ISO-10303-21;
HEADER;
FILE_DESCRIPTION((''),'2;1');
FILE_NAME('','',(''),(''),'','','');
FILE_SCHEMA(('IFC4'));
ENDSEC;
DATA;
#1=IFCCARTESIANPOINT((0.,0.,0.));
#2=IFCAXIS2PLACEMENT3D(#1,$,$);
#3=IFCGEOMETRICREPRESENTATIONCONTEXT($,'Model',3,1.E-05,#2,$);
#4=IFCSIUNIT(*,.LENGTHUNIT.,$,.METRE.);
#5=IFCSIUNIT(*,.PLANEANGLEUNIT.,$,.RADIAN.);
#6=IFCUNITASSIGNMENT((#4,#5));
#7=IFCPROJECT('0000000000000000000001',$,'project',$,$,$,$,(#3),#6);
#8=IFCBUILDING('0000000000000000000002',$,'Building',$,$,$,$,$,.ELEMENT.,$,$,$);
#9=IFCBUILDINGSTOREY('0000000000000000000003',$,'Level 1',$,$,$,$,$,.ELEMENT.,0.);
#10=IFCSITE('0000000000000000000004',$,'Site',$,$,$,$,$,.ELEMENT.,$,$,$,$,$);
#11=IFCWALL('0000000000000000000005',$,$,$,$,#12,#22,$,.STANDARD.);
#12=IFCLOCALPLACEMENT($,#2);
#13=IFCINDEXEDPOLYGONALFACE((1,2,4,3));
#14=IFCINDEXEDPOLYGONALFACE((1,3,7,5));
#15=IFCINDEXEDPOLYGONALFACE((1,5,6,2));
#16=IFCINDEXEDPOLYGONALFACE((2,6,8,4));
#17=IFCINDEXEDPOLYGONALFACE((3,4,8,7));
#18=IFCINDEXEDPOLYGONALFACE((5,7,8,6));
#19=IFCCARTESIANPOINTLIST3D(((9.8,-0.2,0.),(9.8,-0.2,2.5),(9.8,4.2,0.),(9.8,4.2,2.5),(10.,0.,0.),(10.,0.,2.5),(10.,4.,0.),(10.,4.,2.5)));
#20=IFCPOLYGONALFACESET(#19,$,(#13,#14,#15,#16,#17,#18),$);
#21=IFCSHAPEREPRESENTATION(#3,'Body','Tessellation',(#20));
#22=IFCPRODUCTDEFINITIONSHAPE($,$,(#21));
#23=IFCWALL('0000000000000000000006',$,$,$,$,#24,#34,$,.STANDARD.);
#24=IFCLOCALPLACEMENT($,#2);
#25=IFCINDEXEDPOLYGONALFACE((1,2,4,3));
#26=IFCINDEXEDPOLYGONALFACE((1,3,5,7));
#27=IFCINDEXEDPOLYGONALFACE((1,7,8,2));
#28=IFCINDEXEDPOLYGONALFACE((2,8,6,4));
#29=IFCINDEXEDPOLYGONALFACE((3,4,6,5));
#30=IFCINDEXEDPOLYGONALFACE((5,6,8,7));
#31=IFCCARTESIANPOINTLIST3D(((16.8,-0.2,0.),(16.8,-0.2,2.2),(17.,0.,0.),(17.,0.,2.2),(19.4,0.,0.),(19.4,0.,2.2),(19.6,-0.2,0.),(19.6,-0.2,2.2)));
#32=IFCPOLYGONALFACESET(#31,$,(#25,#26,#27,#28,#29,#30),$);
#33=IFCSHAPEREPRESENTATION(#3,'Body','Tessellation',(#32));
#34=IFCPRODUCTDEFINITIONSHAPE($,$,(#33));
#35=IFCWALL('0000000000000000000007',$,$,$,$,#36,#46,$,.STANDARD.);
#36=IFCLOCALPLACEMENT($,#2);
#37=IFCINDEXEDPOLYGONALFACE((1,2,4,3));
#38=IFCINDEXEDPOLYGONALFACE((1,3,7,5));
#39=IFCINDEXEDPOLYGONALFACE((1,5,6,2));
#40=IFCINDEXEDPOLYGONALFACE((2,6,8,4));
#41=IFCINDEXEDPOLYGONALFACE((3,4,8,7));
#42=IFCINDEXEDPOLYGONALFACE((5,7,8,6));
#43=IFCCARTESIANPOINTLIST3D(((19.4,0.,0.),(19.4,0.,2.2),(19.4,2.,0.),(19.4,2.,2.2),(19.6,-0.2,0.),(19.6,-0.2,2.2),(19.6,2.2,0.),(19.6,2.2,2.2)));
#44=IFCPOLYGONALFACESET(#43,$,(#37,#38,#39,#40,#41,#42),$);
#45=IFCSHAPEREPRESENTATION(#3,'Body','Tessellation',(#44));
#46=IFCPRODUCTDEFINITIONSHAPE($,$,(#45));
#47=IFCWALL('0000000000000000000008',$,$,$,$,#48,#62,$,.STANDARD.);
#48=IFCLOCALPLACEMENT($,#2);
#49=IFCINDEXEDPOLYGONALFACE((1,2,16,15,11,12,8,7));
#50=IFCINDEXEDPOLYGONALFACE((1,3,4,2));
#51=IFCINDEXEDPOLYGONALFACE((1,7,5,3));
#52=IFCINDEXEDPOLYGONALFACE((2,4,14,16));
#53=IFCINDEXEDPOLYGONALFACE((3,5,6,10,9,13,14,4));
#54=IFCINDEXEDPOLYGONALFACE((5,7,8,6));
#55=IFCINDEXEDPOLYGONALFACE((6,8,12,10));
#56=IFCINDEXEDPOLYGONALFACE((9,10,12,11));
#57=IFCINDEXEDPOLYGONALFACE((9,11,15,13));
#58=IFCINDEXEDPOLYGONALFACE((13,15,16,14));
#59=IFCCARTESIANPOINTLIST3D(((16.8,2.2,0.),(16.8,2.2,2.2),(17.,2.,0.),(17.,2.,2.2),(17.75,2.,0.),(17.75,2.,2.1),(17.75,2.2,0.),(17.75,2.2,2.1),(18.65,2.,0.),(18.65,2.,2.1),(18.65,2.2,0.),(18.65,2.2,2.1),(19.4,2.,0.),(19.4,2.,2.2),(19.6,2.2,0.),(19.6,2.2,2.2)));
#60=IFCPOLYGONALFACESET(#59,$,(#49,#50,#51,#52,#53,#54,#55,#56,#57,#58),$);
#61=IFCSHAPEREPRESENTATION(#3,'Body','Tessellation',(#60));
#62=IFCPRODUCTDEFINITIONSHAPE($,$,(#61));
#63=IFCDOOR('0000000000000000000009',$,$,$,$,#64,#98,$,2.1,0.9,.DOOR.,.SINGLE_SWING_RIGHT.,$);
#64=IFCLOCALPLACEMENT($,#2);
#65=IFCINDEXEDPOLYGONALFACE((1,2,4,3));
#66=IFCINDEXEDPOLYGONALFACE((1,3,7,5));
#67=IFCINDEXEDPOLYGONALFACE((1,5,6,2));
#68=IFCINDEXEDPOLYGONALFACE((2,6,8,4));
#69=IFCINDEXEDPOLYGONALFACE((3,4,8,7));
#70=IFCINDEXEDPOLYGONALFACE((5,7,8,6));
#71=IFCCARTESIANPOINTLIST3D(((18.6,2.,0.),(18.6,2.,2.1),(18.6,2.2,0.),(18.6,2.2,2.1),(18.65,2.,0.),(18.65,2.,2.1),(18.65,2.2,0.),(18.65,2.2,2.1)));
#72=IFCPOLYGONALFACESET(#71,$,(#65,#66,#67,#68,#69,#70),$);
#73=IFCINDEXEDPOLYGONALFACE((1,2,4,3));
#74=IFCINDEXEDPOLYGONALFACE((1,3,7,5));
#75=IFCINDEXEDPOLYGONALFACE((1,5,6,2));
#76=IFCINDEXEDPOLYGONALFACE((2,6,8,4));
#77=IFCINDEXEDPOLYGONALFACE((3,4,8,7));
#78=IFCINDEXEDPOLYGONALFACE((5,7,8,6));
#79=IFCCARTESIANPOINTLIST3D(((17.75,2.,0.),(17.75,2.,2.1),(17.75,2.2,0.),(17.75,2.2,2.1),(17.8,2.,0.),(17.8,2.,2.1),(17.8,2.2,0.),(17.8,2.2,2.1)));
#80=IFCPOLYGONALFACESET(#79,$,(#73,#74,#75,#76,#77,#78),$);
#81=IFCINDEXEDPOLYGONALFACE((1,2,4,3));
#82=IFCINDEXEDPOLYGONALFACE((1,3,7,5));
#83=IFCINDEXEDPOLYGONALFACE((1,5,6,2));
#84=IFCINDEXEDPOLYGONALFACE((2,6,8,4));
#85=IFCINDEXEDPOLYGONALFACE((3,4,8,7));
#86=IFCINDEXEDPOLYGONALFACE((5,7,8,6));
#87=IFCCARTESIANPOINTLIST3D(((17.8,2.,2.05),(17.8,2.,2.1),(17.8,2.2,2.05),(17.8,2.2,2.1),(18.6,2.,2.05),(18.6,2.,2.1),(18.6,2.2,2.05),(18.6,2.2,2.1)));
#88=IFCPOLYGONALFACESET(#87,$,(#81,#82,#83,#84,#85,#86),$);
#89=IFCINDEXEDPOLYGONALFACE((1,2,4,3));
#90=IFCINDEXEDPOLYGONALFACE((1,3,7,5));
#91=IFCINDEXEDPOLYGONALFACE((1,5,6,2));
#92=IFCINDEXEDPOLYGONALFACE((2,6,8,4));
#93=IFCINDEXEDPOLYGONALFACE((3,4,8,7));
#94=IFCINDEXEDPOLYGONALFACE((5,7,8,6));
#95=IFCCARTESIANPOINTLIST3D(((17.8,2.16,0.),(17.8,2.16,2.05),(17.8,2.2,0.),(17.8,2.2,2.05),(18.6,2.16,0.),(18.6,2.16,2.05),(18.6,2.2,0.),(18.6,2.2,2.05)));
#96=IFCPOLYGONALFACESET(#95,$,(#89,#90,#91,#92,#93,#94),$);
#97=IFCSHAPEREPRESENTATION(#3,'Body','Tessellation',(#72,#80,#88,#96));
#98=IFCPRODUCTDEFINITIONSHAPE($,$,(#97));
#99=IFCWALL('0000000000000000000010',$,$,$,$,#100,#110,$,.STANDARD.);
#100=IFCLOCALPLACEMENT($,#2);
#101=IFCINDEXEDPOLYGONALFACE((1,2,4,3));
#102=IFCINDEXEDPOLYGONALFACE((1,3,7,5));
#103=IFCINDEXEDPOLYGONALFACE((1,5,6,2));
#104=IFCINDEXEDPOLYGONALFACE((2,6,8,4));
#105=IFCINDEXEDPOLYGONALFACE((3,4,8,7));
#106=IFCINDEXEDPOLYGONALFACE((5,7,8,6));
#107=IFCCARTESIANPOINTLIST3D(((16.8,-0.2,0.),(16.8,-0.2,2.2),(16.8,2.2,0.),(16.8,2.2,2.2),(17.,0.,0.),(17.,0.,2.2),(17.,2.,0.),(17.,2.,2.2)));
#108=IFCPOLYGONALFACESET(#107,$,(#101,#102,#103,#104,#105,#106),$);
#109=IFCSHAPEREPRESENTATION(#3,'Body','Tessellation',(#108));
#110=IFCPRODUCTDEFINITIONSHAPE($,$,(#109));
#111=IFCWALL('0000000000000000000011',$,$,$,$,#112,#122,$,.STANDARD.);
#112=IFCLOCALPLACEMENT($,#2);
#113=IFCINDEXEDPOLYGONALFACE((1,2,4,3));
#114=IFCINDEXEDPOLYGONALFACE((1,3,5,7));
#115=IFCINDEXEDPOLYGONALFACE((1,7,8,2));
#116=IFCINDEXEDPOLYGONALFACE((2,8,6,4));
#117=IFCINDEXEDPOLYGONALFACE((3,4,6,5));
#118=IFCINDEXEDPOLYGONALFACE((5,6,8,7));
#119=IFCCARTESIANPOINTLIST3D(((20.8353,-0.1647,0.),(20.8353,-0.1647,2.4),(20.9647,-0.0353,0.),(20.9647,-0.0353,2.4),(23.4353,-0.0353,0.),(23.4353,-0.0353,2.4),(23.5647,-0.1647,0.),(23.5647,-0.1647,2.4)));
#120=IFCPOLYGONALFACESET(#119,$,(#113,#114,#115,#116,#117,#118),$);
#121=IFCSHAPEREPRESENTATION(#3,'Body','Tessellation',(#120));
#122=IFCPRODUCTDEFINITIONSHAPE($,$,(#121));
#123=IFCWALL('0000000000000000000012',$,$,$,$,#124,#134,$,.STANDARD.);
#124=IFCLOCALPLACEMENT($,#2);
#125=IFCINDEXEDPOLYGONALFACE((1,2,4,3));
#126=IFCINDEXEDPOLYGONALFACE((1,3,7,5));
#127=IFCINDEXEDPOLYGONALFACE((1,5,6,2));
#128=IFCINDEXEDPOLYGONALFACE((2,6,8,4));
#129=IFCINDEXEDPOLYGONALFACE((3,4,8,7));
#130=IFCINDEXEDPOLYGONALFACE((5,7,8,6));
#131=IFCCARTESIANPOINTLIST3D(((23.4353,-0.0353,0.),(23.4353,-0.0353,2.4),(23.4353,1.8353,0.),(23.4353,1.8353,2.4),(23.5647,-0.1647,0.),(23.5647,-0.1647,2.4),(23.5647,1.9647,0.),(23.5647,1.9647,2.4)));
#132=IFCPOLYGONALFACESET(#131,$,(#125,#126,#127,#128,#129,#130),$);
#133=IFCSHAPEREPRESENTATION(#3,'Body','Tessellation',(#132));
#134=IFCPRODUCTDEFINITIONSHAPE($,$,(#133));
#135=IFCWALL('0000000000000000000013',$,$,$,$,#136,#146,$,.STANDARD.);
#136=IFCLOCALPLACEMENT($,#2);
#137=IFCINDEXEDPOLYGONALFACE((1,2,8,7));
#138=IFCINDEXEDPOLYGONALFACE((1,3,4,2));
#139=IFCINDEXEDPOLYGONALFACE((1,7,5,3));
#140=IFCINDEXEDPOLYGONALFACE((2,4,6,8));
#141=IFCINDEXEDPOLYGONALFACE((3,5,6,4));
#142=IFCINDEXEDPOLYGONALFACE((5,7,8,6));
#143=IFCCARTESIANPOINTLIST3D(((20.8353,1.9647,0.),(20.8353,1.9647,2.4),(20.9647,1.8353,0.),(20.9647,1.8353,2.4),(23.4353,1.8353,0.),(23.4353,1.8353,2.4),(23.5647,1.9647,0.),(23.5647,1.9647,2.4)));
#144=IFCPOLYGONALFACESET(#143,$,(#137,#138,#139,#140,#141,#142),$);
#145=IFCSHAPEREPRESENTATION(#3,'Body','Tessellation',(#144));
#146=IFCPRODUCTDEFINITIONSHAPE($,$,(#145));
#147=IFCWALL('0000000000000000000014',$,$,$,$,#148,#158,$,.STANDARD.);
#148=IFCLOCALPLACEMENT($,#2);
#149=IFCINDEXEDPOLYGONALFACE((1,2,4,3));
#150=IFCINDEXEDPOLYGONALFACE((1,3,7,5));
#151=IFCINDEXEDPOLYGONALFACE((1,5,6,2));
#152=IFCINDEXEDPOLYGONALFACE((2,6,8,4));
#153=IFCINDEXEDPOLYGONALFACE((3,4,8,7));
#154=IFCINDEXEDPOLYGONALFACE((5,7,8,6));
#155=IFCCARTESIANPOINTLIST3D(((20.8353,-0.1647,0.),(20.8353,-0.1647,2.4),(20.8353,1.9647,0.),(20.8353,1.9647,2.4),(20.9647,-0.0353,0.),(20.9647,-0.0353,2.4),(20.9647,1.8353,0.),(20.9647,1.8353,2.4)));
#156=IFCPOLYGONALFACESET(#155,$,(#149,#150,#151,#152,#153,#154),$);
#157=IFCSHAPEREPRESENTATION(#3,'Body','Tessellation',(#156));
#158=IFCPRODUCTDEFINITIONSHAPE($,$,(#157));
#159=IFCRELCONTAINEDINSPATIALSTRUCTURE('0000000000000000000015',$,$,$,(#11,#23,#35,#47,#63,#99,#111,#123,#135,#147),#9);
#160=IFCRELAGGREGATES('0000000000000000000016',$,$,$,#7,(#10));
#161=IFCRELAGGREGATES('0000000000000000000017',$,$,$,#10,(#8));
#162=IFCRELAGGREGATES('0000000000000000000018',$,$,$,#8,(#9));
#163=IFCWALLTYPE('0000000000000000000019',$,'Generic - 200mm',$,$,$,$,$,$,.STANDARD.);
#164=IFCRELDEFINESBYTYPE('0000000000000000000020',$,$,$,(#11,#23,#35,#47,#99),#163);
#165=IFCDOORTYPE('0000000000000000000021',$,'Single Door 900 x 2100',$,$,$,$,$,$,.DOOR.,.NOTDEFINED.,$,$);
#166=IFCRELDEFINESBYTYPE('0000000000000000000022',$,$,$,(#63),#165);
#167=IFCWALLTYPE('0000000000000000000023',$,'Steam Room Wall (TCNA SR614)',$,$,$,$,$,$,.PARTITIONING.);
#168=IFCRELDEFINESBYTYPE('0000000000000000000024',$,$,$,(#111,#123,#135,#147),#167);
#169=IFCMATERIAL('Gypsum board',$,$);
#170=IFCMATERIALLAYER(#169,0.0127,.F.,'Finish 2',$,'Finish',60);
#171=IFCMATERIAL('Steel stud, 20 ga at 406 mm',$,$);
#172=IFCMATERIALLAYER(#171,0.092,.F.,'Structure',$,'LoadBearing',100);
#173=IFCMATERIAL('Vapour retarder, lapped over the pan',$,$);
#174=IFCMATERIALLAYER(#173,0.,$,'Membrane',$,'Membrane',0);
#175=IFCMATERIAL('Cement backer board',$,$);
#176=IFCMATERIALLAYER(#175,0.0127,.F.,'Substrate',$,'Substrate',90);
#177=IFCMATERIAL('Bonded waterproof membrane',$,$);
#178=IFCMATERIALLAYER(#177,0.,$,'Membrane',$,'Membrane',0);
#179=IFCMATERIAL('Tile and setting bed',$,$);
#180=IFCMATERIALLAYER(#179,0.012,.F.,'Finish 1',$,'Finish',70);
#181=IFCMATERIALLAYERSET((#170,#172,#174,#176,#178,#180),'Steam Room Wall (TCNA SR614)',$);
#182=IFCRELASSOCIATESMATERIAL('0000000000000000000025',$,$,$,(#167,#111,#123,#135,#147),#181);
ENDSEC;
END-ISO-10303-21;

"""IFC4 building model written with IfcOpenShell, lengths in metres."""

from ifc_helpers import new_model, si_unit, frame, frame_2d, origin, origin_with_axes, origin_2d, place, context, project, spatial, polyline, rectangle, outline, extrude, material, layer, layer_set, layer_usage, type_object, element, fill, save


model = new_model("IFC4")

# Units and contexts
model_context = context("Model", 3, precision=1e-05, world=origin())
ifc_project = project(units=[si_unit("LENGTHUNIT", "METRE"), si_unit("PLANEANGLEUNIT", "RADIAN")], contexts=[model_context])

# Site, building, storey
site = spatial("IfcSite", under=ifc_project, Name="Site", CompositionType="ELEMENT")
building = spatial("IfcBuilding", under=site, Name="Building", CompositionType="ELEMENT")
storey = spatial("IfcBuildingStorey", under=building, Name="Level 1", CompositionType="ELEMENT", Elevation=0.0)

# Walls
wall_type_1 = type_object("IfcWallType", Name="Generic - 200mm", PredefinedType="STANDARD")
wall_1_placement = place(None, frame((9.9, 4.1, 0.0), z_axis=(0.0, 0.0, 1.0), x_axis=(0.0, -1.0, 0.0)))
element("IfcWall", 1, at=wall_1_placement, inside=storey, type_object=wall_type_1, PredefinedType="STANDARD", context=model_context, shape_type="SweptSolid", body=[
    extrude(outline(polyline([(-0.1, -0.1), (4.3, -0.1), (4.1, 0.1), (0.1, 0.1), (-0.1, -0.1)])), origin(), (0.0, 0.0, 1.0), 2.5),
])
wall_2_placement = place(None, frame((16.9, -0.1, 0.0), z_axis=(0.0, 0.0, 1.0), x_axis=(1.0, 0.0, 0.0)))
element("IfcWall", 2, at=wall_2_placement, inside=storey, type_object=wall_type_1, PredefinedType="STANDARD", context=model_context, shape_type="SweptSolid", body=[
    extrude(outline(polyline([(-0.1, -0.1), (2.7, -0.1), (2.5, 0.1), (0.1, 0.1), (-0.1, -0.1)])), origin(), (0.0, 0.0, 1.0), 2.2),
])
wall_3_placement = place(None, frame((19.5, -0.1, 0.0), z_axis=(0.0, 0.0, 1.0), x_axis=(0.0, 1.0, 0.0)))
element("IfcWall", 3, at=wall_3_placement, inside=storey, type_object=wall_type_1, PredefinedType="STANDARD", context=model_context, shape_type="SweptSolid", body=[
    extrude(outline(polyline([(-0.1, -0.1), (2.3, -0.1), (2.1, 0.1), (0.1, 0.1), (-0.1, -0.1)])), origin(), (0.0, 0.0, 1.0), 2.2),
])

# Wall, opening, door
wall_4_placement = place(None, frame((19.5, 2.1, 0.0), z_axis=(0.0, 0.0, 1.0), x_axis=(-1.0, 0.0, 0.0)))
wall_4 = element("IfcWall", 4, at=wall_4_placement, inside=storey, type_object=wall_type_1, PredefinedType="STANDARD", context=model_context, shape_type="SweptSolid", body=[
    extrude(outline(polyline([(-0.1, -0.1), (2.7, -0.1), (2.5, 0.1), (0.1, 0.1), (-0.1, -0.1)])), origin(), (0.0, 0.0, 1.0), 2.2),
])
opening_placement = place(wall_4_placement, frame((1.3, 0.0, 0.0), z_axis=(0.0, 0.0, 1.0), x_axis=(1.0, 0.0, 0.0)))
opening = element("IfcOpeningElement", 5, at=opening_placement, cuts=wall_4, PredefinedType="OPENING", context=model_context, shape_type="SweptSolid", body=[
    extrude(rectangle(XDim=0.9, YDim=0.202, at=origin_2d()), origin(), (0.0, 0.0, 1.0), 2.1),
])
door_type = type_object("IfcDoorType", Name="Single Door 900 x 2100", OperationType="NOTDEFINED", PredefinedType="DOOR")
door_placement = place(opening_placement, origin_with_axes())
door = element("IfcDoor", 6, at=door_placement, inside=storey, type_object=door_type, OperationType="SINGLE_SWING_RIGHT", OverallHeight=2.1, OverallWidth=0.9, PredefinedType="DOOR", context=model_context, shape_type="SweptSolid", body=[
    extrude(rectangle(XDim=0.05, YDim=0.2, at=frame_2d((-0.425, 0.0))), origin(), (0.0, 0.0, 1.0), 2.1),
    extrude(rectangle(XDim=0.05, YDim=0.2, at=frame_2d((0.425, 0.0))), origin(), (0.0, 0.0, 1.0), 2.1),
    extrude(rectangle(XDim=0.8, YDim=0.2, at=origin_2d()), frame((0.0, 0.0, 2.05)), (0.0, 0.0, 1.0), 0.05),
    extrude(rectangle(XDim=0.8, YDim=0.04, at=frame_2d((0.0, -0.08))), origin(), (0.0, 0.0, 1.0), 2.05),
])
fill(opening, door)

# Walls
wall_5_placement = place(None, frame((16.9, 2.1, 0.0), z_axis=(0.0, 0.0, 1.0), x_axis=(0.0, -1.0, 0.0)))
element("IfcWall", 7, at=wall_5_placement, inside=storey, type_object=wall_type_1, PredefinedType="STANDARD", context=model_context, shape_type="SweptSolid", body=[
    extrude(outline(polyline([(-0.1, -0.1), (2.3, -0.1), (2.1, 0.1), (0.1, 0.1), (-0.1, -0.1)])), origin(), (0.0, 0.0, 1.0), 2.2),
])
ifc_material_1 = material(Name="Gypsum board")
ifc_layer_1 = layer(ifc_material_1, 0.0127, ventilated=False, Name="Finish 2", Category="Finish", Priority=60)
ifc_material_2 = material(Name="Steel stud, 20 ga at 406 mm")
ifc_layer_2 = layer(ifc_material_2, 0.092, ventilated=False, Name="Structure", Category="LoadBearing", Priority=100)
ifc_material_3 = material(Name="Vapour retarder, lapped over the pan")
ifc_layer_3 = layer(ifc_material_3, 0.0, Name="Membrane", Category="Membrane", Priority=0)
ifc_material_4 = material(Name="Cement backer board")
ifc_layer_4 = layer(ifc_material_4, 0.0127, ventilated=False, Name="Substrate", Category="Substrate", Priority=90)
ifc_material_5 = material(Name="Bonded waterproof membrane")
ifc_layer_5 = layer(ifc_material_5, 0.0, Name="Membrane", Category="Membrane", Priority=0)
ifc_material_6 = material(Name="Tile and setting bed")
ifc_layer_6 = layer(ifc_material_6, 0.012, ventilated=False, Name="Finish 1", Category="Finish", Priority=70)
ifc_layer_set = layer_set([ifc_layer_1, ifc_layer_2, ifc_layer_3, ifc_layer_4, ifc_layer_5, ifc_layer_6], Name="Steam Room Wall (TCNA SR614)")
ifc_layer_usage = layer_usage(ifc_layer_set, "AXIS2", "POSITIVE", -0.0647)
wall_type_2 = type_object("IfcWallType", Name="Steam Room Wall (TCNA SR614)", PredefinedType="PARTITIONING", material=ifc_layer_set)
wall_6_placement = place(None, frame((20.9, -0.1, 0.0), z_axis=(0.0, 0.0, 1.0), x_axis=(1.0, 0.0, 0.0)))
element("IfcWall", 8, at=wall_6_placement, inside=storey, type_object=wall_type_2, material=ifc_layer_usage, PredefinedType="STANDARD", context=model_context, shape_type="SweptSolid", body=[
    extrude(outline(polyline([(-0.0647, -0.0647), (2.6647, -0.0647), (2.5353, 0.0647), (0.0647, 0.0647), (-0.0647, -0.0647)])), origin(), (0.0, 0.0, 1.0), 2.4),
])
wall_7_placement = place(None, frame((23.5, -0.1, 0.0), z_axis=(0.0, 0.0, 1.0), x_axis=(0.0, 1.0, 0.0)))
element("IfcWall", 9, at=wall_7_placement, inside=storey, type_object=wall_type_2, material=ifc_layer_usage, PredefinedType="STANDARD", context=model_context, shape_type="SweptSolid", body=[
    extrude(outline(polyline([(-0.0647, -0.0647), (2.0647, -0.0647), (1.9353, 0.0647), (0.0647, 0.0647), (-0.0647, -0.0647)])), origin(), (0.0, 0.0, 1.0), 2.4),
])
wall_8_placement = place(None, frame((23.5, 1.9, 0.0), z_axis=(0.0, 0.0, 1.0), x_axis=(-1.0, 0.0, 0.0)))
element("IfcWall", 10, at=wall_8_placement, inside=storey, type_object=wall_type_2, material=ifc_layer_usage, PredefinedType="STANDARD", context=model_context, shape_type="SweptSolid", body=[
    extrude(outline(polyline([(-0.0647, -0.0647), (2.6647, -0.0647), (2.5353, 0.0647), (0.0647, 0.0647), (-0.0647, -0.0647)])), origin(), (0.0, 0.0, 1.0), 2.4),
])
wall_9_placement = place(None, frame((20.9, 1.9, 0.0), z_axis=(0.0, 0.0, 1.0), x_axis=(0.0, -1.0, 0.0)))
element("IfcWall", 11, at=wall_9_placement, inside=storey, type_object=wall_type_2, material=ifc_layer_usage, PredefinedType="STANDARD", context=model_context, shape_type="SweptSolid", body=[
    extrude(outline(polyline([(-0.0647, -0.0647), (2.0647, -0.0647), (1.9353, 0.0647), (0.0647, 0.0647), (-0.0647, -0.0647)])), origin(), (0.0, 0.0, 1.0), 2.4),
])

save(model, "model.ifc")
